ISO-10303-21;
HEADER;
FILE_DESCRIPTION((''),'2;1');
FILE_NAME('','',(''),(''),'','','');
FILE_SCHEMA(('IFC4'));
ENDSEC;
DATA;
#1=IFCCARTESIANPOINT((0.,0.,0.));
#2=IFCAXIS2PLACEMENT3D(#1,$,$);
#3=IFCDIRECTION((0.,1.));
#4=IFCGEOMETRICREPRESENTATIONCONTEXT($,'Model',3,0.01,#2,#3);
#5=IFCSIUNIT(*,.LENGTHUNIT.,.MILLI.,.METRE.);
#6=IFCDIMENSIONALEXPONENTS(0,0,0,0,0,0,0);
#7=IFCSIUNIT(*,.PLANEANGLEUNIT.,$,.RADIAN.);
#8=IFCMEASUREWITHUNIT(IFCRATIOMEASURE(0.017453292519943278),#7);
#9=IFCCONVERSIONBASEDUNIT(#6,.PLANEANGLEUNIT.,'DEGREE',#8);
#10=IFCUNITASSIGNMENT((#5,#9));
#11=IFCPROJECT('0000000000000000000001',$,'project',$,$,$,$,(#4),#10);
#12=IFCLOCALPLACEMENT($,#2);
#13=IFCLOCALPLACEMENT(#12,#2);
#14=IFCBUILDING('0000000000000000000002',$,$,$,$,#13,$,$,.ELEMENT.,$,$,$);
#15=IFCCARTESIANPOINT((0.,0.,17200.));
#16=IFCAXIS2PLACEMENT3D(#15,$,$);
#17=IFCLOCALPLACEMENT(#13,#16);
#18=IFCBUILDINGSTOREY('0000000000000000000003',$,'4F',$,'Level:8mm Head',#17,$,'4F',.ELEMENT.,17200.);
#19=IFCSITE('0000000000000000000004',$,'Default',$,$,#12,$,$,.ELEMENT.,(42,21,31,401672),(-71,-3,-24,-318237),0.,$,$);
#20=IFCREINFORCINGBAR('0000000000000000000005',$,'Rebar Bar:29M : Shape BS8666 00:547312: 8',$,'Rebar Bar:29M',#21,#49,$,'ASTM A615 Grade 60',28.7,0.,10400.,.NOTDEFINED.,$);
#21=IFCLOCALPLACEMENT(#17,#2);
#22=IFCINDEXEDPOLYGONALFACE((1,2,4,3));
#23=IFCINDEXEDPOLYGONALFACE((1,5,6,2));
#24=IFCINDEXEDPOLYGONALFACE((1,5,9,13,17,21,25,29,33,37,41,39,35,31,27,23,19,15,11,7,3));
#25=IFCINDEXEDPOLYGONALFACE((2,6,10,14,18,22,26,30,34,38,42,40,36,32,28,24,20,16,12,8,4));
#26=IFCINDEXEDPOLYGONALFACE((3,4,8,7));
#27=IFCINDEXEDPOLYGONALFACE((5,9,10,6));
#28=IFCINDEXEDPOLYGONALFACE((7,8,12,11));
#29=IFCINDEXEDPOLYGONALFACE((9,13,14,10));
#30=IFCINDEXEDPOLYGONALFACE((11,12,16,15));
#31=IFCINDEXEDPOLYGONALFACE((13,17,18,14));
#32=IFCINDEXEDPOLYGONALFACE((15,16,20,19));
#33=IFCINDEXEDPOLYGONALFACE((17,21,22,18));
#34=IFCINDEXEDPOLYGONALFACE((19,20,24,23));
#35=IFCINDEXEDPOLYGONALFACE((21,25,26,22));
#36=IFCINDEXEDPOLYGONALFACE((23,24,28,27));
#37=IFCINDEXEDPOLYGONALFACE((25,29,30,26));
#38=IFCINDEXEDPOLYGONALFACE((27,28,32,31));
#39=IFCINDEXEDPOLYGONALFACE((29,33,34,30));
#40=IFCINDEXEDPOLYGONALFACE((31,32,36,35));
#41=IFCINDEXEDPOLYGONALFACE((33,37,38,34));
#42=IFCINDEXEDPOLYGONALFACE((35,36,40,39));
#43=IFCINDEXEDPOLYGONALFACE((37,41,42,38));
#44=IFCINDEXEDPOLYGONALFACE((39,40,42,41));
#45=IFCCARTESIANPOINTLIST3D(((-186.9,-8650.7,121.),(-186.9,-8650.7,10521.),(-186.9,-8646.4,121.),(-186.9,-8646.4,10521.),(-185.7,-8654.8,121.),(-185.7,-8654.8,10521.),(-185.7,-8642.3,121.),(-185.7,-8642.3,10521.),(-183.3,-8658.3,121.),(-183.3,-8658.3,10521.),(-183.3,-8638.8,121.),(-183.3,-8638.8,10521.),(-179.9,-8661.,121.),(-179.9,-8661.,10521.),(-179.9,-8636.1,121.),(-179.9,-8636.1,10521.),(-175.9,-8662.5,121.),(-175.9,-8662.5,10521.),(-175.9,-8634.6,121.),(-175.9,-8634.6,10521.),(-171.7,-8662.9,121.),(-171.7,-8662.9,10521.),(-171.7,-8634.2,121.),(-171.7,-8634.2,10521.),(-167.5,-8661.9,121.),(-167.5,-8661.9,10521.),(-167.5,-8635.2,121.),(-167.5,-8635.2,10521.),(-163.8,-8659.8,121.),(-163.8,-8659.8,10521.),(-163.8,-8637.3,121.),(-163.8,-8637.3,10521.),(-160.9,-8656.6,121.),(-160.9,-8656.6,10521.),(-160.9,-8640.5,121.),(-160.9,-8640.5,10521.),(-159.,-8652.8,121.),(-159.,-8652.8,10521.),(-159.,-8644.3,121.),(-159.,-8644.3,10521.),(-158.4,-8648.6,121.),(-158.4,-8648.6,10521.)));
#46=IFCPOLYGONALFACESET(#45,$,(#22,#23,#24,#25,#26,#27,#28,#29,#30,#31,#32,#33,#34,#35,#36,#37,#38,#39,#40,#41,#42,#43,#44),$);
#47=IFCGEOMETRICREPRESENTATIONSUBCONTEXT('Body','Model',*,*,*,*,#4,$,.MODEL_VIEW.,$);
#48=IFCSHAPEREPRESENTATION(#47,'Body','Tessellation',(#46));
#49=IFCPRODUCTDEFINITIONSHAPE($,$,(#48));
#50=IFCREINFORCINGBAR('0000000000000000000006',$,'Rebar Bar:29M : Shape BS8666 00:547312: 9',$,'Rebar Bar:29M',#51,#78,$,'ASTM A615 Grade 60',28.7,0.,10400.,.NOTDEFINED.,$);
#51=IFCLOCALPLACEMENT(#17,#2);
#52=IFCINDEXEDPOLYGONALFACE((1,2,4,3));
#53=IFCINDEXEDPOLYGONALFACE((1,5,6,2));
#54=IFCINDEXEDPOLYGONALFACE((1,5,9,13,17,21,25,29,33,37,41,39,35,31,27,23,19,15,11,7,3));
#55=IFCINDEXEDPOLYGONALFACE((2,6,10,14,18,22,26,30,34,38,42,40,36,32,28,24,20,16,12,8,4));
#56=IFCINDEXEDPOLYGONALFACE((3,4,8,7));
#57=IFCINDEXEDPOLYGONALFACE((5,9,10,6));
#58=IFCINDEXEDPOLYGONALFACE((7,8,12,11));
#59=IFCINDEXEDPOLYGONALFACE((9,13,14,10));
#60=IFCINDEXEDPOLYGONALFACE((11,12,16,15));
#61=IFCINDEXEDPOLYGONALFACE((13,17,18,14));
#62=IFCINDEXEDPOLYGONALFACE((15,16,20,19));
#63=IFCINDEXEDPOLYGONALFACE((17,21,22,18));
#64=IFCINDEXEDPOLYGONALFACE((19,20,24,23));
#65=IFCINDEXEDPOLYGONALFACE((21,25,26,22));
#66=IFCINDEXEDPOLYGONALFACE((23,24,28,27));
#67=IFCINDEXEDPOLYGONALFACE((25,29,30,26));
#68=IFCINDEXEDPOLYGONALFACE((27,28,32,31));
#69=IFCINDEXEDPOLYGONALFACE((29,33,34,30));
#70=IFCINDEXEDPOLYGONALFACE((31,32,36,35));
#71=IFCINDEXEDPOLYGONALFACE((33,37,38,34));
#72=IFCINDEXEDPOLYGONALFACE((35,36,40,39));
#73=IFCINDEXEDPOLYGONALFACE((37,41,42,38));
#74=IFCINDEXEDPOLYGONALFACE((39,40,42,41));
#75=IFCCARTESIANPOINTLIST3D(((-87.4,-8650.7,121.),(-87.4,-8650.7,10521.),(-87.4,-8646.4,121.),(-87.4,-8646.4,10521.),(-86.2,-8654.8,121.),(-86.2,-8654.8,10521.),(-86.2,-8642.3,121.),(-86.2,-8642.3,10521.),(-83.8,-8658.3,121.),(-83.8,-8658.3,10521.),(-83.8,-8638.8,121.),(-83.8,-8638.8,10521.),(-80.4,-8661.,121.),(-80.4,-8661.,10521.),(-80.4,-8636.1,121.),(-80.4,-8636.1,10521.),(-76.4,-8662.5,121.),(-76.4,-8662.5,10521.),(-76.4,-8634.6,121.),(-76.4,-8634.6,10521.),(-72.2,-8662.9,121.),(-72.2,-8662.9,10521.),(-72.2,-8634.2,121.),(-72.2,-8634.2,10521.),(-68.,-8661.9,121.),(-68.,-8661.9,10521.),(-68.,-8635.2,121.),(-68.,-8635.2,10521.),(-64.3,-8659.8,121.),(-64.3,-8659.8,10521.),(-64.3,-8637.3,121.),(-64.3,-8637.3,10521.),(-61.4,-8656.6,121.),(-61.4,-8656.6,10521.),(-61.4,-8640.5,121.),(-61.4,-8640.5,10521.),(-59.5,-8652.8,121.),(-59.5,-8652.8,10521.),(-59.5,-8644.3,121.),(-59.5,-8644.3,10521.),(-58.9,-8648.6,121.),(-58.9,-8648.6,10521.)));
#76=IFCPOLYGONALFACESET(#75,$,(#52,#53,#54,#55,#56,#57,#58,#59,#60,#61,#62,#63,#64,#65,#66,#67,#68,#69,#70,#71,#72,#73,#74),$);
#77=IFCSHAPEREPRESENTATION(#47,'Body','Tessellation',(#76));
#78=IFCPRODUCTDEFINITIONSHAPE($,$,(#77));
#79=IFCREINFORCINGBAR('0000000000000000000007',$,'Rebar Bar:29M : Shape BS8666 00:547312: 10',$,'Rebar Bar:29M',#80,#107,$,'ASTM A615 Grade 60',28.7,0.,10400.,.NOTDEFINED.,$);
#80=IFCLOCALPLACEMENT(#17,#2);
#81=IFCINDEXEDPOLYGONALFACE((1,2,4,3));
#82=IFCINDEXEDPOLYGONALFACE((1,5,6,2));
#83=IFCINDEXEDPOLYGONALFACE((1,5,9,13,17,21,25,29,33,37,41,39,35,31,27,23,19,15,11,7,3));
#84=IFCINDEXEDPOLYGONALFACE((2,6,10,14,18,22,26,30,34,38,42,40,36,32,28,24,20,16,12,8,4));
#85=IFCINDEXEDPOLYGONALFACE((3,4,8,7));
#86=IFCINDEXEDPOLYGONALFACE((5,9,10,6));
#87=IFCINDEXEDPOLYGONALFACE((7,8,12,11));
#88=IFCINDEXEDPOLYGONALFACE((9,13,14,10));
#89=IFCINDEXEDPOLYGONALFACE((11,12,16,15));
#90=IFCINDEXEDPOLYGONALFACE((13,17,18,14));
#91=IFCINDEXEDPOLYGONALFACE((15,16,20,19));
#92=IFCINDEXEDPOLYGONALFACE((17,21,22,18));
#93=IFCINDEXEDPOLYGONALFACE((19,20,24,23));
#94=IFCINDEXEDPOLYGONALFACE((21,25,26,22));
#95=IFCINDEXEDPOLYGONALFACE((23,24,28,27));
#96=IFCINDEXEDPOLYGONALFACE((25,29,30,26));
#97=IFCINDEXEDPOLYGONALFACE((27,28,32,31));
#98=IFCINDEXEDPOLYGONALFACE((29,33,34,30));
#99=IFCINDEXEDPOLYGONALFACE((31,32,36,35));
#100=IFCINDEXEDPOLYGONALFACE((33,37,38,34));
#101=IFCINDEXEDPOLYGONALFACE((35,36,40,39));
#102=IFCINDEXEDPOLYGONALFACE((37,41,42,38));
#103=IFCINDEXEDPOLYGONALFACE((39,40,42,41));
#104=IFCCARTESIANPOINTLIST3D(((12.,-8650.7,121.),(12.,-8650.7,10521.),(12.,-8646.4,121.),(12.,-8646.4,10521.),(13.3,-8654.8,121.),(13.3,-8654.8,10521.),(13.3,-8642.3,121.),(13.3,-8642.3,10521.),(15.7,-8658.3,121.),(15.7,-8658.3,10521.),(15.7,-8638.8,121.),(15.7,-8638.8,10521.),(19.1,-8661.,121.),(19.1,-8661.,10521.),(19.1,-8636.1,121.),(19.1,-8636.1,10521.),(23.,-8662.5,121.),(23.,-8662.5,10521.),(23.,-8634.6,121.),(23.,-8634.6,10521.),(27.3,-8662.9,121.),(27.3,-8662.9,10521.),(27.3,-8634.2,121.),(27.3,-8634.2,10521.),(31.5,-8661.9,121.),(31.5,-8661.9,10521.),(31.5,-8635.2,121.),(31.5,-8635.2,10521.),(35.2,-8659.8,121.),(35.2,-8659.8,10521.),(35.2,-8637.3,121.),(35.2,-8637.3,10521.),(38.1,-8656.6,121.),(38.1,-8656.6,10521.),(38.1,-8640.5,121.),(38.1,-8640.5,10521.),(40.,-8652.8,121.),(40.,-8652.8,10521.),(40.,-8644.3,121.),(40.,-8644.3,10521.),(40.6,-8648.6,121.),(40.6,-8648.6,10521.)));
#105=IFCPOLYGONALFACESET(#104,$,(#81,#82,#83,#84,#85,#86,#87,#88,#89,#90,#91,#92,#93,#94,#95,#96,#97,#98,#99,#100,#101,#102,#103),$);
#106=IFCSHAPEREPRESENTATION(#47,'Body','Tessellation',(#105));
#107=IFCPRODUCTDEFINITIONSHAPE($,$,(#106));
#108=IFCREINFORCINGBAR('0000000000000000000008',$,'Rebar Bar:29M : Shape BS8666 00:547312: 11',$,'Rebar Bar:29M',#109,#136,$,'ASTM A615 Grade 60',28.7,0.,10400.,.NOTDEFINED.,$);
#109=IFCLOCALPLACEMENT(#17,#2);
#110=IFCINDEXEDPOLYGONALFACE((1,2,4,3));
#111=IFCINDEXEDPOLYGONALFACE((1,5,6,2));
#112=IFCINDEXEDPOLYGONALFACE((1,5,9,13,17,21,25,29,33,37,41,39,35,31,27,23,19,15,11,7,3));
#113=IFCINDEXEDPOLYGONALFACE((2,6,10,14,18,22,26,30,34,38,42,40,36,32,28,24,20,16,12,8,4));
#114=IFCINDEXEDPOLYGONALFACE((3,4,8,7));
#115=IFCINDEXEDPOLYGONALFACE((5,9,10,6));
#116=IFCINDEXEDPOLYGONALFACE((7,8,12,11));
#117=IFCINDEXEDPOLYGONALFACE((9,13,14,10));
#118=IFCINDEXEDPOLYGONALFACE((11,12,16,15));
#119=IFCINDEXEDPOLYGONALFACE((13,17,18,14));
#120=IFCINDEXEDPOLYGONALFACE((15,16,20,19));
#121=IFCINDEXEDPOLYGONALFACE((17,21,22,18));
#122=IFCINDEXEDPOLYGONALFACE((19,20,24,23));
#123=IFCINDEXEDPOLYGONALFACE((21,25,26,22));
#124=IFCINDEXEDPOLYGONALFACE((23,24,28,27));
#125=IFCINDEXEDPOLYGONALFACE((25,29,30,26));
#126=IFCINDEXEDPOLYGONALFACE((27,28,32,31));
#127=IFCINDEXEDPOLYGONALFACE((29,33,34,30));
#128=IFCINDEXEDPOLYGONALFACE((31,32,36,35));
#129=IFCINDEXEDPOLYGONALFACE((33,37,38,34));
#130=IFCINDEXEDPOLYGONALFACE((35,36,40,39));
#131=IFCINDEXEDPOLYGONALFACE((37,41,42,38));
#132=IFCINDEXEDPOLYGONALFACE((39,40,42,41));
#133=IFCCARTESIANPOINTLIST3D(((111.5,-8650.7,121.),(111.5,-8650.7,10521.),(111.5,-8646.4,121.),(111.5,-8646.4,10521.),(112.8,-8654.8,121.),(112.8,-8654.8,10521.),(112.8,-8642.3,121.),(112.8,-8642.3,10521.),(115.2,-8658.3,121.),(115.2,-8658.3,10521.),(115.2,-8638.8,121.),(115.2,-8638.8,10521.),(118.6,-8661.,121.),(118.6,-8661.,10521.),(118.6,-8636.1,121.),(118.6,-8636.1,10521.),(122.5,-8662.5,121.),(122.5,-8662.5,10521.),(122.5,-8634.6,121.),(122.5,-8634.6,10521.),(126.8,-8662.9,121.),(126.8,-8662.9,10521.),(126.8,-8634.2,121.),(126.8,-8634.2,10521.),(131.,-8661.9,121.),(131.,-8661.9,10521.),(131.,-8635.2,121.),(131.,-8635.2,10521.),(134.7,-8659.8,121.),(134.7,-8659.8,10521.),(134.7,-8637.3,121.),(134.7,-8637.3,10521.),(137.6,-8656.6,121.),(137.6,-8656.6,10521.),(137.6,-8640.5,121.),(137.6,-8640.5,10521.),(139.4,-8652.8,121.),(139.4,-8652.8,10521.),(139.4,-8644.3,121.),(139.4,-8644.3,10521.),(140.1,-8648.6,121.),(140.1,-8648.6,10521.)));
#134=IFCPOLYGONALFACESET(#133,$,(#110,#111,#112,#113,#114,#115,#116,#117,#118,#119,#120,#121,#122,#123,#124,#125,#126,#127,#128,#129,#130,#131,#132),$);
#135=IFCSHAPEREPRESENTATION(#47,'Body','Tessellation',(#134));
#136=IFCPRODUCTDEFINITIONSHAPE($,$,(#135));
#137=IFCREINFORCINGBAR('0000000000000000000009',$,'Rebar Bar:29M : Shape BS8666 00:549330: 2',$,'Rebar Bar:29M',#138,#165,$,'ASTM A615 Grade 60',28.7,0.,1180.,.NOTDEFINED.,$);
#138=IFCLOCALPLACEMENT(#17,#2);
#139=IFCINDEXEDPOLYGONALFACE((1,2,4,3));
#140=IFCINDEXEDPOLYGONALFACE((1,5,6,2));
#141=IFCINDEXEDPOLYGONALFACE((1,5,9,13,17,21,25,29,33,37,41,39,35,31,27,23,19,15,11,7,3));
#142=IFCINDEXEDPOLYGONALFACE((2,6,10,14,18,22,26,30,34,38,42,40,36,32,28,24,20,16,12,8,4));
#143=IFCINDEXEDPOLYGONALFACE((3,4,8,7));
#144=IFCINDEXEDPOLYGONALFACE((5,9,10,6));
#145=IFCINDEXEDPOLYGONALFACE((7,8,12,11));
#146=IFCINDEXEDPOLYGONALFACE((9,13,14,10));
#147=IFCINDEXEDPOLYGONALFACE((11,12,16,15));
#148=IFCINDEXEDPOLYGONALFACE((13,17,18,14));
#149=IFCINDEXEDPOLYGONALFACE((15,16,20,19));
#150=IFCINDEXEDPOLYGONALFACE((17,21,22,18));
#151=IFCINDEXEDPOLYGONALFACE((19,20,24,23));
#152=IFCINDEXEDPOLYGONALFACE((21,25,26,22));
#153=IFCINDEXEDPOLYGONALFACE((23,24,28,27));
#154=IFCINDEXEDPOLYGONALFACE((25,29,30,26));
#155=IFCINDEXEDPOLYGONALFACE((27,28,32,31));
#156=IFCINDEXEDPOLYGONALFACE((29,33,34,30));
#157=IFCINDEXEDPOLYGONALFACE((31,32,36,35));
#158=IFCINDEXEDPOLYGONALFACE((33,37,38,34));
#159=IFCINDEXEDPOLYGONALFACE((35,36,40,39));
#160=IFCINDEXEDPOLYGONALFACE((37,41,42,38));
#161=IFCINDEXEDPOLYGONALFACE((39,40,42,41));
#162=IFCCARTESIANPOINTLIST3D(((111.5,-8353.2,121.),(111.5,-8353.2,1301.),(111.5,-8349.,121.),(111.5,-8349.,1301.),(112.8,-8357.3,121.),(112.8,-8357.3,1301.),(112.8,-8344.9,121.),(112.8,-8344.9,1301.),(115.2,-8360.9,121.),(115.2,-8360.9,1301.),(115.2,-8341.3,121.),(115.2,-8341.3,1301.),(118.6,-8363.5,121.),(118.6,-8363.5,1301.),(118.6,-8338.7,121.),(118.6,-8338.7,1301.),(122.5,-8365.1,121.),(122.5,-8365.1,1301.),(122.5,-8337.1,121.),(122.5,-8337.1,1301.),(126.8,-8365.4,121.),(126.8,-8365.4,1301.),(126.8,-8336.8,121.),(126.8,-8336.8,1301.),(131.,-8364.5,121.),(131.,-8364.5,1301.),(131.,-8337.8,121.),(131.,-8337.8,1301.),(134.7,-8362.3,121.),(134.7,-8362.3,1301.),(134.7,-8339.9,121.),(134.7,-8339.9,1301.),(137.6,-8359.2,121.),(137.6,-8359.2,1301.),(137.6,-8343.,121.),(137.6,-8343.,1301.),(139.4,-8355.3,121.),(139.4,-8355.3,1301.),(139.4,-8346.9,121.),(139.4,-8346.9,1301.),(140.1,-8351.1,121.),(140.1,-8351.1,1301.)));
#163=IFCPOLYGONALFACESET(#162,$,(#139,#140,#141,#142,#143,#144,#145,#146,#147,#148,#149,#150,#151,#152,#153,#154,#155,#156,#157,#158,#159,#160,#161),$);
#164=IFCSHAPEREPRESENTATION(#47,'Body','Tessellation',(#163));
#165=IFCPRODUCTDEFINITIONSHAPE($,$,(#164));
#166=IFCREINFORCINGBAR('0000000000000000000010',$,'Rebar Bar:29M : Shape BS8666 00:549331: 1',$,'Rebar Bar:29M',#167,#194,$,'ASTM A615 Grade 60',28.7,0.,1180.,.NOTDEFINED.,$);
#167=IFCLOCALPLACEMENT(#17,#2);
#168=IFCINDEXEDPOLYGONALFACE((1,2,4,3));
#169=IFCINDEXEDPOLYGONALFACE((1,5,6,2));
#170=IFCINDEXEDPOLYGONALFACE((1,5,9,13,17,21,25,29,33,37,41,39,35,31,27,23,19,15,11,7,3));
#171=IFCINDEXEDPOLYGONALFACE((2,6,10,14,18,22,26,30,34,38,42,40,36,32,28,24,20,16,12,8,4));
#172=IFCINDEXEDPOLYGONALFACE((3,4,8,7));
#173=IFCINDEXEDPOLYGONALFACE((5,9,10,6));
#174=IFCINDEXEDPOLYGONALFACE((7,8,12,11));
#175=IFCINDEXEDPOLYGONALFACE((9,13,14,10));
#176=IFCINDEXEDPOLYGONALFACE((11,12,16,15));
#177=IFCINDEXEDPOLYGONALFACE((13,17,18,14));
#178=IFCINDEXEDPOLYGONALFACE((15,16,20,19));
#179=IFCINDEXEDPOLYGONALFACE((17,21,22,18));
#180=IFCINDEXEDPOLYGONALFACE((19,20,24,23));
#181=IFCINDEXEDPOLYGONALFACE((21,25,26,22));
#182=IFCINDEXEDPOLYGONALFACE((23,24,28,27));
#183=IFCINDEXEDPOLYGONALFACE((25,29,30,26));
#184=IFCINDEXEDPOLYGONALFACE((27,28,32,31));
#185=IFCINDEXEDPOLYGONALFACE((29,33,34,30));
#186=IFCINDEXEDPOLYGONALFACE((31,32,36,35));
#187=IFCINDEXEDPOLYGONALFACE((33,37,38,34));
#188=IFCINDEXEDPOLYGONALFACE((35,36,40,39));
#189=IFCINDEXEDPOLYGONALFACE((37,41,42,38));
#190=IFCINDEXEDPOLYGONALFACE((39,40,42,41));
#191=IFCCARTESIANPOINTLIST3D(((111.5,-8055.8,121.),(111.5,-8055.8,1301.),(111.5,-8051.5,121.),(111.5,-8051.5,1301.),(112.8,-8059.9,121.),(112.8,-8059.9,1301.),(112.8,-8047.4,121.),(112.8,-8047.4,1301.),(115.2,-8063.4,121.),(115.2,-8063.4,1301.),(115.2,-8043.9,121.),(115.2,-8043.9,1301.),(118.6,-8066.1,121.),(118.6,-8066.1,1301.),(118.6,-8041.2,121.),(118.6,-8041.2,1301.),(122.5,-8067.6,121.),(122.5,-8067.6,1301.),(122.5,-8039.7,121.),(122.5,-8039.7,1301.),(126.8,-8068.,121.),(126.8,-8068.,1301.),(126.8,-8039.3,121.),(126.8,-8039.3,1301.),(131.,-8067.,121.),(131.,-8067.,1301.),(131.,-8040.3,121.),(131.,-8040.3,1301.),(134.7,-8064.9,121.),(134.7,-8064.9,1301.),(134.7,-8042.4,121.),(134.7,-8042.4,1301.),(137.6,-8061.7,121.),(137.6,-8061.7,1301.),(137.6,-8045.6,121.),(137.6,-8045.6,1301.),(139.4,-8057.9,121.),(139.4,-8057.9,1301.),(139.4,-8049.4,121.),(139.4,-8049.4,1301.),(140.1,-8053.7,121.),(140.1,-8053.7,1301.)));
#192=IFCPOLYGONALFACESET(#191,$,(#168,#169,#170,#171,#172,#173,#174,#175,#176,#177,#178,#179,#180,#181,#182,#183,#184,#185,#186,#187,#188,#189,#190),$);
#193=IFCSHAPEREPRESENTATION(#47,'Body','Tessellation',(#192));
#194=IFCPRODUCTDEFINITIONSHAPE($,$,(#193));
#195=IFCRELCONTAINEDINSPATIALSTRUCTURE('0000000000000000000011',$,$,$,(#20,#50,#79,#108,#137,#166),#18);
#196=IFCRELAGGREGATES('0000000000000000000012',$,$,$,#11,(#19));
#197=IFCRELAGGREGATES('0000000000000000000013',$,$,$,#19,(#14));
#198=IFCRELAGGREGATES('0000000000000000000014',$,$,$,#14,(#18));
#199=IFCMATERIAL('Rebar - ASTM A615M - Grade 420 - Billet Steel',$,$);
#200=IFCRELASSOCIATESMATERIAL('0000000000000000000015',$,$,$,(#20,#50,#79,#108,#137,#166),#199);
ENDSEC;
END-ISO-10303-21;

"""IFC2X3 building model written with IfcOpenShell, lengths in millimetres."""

from ifc_helpers import new_model, entity, si_unit, converted_unit, direction, frame, origin, place, context, subcontext, project, spatial, material, element, save


model = new_model("IFC2X3")

# Units and contexts
model_context = context("Model", 3, precision=0.01, world=origin(), true_north=direction((0.0, 1.0)))
body_context = subcontext(model_context, "Body", "Model", "MODEL_VIEW")
ifc_project = project(units=[si_unit("LENGTHUNIT", "METRE", prefix="MILLI"), converted_unit("PLANEANGLEUNIT", "DEGREE", entity("IfcRatioMeasure", 0.017453292519943278), si_unit("PLANEANGLEUNIT", "RADIAN"), dimensions=[0, 0, 0, 0, 0, 0, 0])], contexts=[model_context])

# Site, building, storey
site_placement = place(None, origin())
site = spatial("IfcSite", under=ifc_project, at=site_placement, Name="Default", CompositionType="ELEMENT", RefLatitude=(42, 21, 31, 401672), RefLongitude=(-71, -3, -24, -318237), RefElevation=0.0)
building_placement = place(site_placement, origin())
building = spatial("IfcBuilding", under=site, at=building_placement, CompositionType="ELEMENT")
storey_placement = place(building_placement, frame((0.0, 0.0, 17200.0)))
storey = spatial("IfcBuildingStorey", under=building, at=storey_placement, Name="4F", ObjectType="Level:8mm Head", LongName="4F", CompositionType="ELEMENT", Elevation=17200.0)

# Reinforcing bars
ifc_material_1 = material(Name="Rebar - ASTM A615M - Grade 420 - Billet Steel")
reinforcing_bar_1_placement = place(storey_placement, origin())
element("IfcReinforcingBar", 1, at=reinforcing_bar_1_placement, inside=storey, material=ifc_material_1, Name="Rebar Bar:29M : Shape BS8666 00:547312: 8", SteelGrade="ASTM A615 Grade 60", ObjectType="Rebar Bar:29M", BarLength=10400.0, BarRole="NOTDEFINED", CrossSectionArea=0.0, NominalDiameter=28.7, context=body_context, shape_type="AdvancedSweptSolid", body=[
    entity("IfcSweptDiskSolid", entity("IfcCompositeCurve", [entity("IfcCompositeCurveSegment", "CONTINUOUS", True, entity("IfcPolyline", [entity("IfcCartesianPoint", [-172.7, -8648.6, 121.0]), entity("IfcCartesianPoint", [-172.7, -8648.6, 10521.0])]))], False), 14.3, None, 0.0, 1.0),
])
reinforcing_bar_2_placement = place(storey_placement, origin())
element("IfcReinforcingBar", 2, at=reinforcing_bar_2_placement, inside=storey, material=ifc_material_1, Name="Rebar Bar:29M : Shape BS8666 00:547312: 9", SteelGrade="ASTM A615 Grade 60", ObjectType="Rebar Bar:29M", BarLength=10400.0, BarRole="NOTDEFINED", CrossSectionArea=0.0, NominalDiameter=28.7, context=body_context, shape_type="AdvancedSweptSolid", body=[
    entity("IfcSweptDiskSolid", entity("IfcCompositeCurve", [entity("IfcCompositeCurveSegment", "CONTINUOUS", True, entity("IfcPolyline", [entity("IfcCartesianPoint", [-73.3, -8648.6, 121.0]), entity("IfcCartesianPoint", [-73.3, -8648.6, 10521.0])]))], False), 14.3, None, 0.0, 1.0),
])
reinforcing_bar_3_placement = place(storey_placement, origin())
element("IfcReinforcingBar", 3, at=reinforcing_bar_3_placement, inside=storey, material=ifc_material_1, Name="Rebar Bar:29M : Shape BS8666 00:547312: 10", SteelGrade="ASTM A615 Grade 60", ObjectType="Rebar Bar:29M", BarLength=10400.0, BarRole="NOTDEFINED", CrossSectionArea=0.0, NominalDiameter=28.7, context=body_context, shape_type="AdvancedSweptSolid", body=[
    entity("IfcSweptDiskSolid", entity("IfcCompositeCurve", [entity("IfcCompositeCurveSegment", "CONTINUOUS", True, entity("IfcPolyline", [entity("IfcCartesianPoint", [26.2, -8648.6, 121.0]), entity("IfcCartesianPoint", [26.2, -8648.6, 10521.0])]))], False), 14.3, None, 0.0, 1.0),
])
reinforcing_bar_4_placement = place(storey_placement, origin())
element("IfcReinforcingBar", 4, at=reinforcing_bar_4_placement, inside=storey, material=ifc_material_1, Name="Rebar Bar:29M : Shape BS8666 00:547312: 11", SteelGrade="ASTM A615 Grade 60", ObjectType="Rebar Bar:29M", BarLength=10400.0, BarRole="NOTDEFINED", CrossSectionArea=0.0, NominalDiameter=28.7, context=body_context, shape_type="AdvancedSweptSolid", body=[
    entity("IfcSweptDiskSolid", entity("IfcCompositeCurve", [entity("IfcCompositeCurveSegment", "CONTINUOUS", True, entity("IfcPolyline", [entity("IfcCartesianPoint", [125.7, -8648.6, 121.0]), entity("IfcCartesianPoint", [125.7, -8648.6, 10521.0])]))], False), 14.3, None, 0.0, 1.0),
])
reinforcing_bar_5_placement = place(storey_placement, origin())
element("IfcReinforcingBar", 5, at=reinforcing_bar_5_placement, inside=storey, material=ifc_material_1, Name="Rebar Bar:29M : Shape BS8666 00:549330: 2", SteelGrade="ASTM A615 Grade 60", ObjectType="Rebar Bar:29M", BarLength=1180.0, BarRole="NOTDEFINED", CrossSectionArea=0.0, NominalDiameter=28.7, context=body_context, shape_type="AdvancedSweptSolid", body=[
    entity("IfcSweptDiskSolid", entity("IfcCompositeCurve", [entity("IfcCompositeCurveSegment", "CONTINUOUS", True, entity("IfcPolyline", [entity("IfcCartesianPoint", [125.7, -8351.1, 121.0]), entity("IfcCartesianPoint", [125.7, -8351.1, 1301.0])]))], False), 14.3, None, 0.0, 1.0),
])
reinforcing_bar_6_placement = place(storey_placement, origin())
element("IfcReinforcingBar", 6, at=reinforcing_bar_6_placement, inside=storey, material=ifc_material_1, Name="Rebar Bar:29M : Shape BS8666 00:549331: 1", SteelGrade="ASTM A615 Grade 60", ObjectType="Rebar Bar:29M", BarLength=1180.0, BarRole="NOTDEFINED", CrossSectionArea=0.0, NominalDiameter=28.7, context=body_context, shape_type="AdvancedSweptSolid", body=[
    entity("IfcSweptDiskSolid", entity("IfcCompositeCurve", [entity("IfcCompositeCurveSegment", "CONTINUOUS", True, entity("IfcPolyline", [entity("IfcCartesianPoint", [125.7, -8053.7, 121.0]), entity("IfcCartesianPoint", [125.7, -8053.7, 1301.0])]))], False), 14.3, None, 0.0, 1.0),
])

save(model, "model.ifc")
